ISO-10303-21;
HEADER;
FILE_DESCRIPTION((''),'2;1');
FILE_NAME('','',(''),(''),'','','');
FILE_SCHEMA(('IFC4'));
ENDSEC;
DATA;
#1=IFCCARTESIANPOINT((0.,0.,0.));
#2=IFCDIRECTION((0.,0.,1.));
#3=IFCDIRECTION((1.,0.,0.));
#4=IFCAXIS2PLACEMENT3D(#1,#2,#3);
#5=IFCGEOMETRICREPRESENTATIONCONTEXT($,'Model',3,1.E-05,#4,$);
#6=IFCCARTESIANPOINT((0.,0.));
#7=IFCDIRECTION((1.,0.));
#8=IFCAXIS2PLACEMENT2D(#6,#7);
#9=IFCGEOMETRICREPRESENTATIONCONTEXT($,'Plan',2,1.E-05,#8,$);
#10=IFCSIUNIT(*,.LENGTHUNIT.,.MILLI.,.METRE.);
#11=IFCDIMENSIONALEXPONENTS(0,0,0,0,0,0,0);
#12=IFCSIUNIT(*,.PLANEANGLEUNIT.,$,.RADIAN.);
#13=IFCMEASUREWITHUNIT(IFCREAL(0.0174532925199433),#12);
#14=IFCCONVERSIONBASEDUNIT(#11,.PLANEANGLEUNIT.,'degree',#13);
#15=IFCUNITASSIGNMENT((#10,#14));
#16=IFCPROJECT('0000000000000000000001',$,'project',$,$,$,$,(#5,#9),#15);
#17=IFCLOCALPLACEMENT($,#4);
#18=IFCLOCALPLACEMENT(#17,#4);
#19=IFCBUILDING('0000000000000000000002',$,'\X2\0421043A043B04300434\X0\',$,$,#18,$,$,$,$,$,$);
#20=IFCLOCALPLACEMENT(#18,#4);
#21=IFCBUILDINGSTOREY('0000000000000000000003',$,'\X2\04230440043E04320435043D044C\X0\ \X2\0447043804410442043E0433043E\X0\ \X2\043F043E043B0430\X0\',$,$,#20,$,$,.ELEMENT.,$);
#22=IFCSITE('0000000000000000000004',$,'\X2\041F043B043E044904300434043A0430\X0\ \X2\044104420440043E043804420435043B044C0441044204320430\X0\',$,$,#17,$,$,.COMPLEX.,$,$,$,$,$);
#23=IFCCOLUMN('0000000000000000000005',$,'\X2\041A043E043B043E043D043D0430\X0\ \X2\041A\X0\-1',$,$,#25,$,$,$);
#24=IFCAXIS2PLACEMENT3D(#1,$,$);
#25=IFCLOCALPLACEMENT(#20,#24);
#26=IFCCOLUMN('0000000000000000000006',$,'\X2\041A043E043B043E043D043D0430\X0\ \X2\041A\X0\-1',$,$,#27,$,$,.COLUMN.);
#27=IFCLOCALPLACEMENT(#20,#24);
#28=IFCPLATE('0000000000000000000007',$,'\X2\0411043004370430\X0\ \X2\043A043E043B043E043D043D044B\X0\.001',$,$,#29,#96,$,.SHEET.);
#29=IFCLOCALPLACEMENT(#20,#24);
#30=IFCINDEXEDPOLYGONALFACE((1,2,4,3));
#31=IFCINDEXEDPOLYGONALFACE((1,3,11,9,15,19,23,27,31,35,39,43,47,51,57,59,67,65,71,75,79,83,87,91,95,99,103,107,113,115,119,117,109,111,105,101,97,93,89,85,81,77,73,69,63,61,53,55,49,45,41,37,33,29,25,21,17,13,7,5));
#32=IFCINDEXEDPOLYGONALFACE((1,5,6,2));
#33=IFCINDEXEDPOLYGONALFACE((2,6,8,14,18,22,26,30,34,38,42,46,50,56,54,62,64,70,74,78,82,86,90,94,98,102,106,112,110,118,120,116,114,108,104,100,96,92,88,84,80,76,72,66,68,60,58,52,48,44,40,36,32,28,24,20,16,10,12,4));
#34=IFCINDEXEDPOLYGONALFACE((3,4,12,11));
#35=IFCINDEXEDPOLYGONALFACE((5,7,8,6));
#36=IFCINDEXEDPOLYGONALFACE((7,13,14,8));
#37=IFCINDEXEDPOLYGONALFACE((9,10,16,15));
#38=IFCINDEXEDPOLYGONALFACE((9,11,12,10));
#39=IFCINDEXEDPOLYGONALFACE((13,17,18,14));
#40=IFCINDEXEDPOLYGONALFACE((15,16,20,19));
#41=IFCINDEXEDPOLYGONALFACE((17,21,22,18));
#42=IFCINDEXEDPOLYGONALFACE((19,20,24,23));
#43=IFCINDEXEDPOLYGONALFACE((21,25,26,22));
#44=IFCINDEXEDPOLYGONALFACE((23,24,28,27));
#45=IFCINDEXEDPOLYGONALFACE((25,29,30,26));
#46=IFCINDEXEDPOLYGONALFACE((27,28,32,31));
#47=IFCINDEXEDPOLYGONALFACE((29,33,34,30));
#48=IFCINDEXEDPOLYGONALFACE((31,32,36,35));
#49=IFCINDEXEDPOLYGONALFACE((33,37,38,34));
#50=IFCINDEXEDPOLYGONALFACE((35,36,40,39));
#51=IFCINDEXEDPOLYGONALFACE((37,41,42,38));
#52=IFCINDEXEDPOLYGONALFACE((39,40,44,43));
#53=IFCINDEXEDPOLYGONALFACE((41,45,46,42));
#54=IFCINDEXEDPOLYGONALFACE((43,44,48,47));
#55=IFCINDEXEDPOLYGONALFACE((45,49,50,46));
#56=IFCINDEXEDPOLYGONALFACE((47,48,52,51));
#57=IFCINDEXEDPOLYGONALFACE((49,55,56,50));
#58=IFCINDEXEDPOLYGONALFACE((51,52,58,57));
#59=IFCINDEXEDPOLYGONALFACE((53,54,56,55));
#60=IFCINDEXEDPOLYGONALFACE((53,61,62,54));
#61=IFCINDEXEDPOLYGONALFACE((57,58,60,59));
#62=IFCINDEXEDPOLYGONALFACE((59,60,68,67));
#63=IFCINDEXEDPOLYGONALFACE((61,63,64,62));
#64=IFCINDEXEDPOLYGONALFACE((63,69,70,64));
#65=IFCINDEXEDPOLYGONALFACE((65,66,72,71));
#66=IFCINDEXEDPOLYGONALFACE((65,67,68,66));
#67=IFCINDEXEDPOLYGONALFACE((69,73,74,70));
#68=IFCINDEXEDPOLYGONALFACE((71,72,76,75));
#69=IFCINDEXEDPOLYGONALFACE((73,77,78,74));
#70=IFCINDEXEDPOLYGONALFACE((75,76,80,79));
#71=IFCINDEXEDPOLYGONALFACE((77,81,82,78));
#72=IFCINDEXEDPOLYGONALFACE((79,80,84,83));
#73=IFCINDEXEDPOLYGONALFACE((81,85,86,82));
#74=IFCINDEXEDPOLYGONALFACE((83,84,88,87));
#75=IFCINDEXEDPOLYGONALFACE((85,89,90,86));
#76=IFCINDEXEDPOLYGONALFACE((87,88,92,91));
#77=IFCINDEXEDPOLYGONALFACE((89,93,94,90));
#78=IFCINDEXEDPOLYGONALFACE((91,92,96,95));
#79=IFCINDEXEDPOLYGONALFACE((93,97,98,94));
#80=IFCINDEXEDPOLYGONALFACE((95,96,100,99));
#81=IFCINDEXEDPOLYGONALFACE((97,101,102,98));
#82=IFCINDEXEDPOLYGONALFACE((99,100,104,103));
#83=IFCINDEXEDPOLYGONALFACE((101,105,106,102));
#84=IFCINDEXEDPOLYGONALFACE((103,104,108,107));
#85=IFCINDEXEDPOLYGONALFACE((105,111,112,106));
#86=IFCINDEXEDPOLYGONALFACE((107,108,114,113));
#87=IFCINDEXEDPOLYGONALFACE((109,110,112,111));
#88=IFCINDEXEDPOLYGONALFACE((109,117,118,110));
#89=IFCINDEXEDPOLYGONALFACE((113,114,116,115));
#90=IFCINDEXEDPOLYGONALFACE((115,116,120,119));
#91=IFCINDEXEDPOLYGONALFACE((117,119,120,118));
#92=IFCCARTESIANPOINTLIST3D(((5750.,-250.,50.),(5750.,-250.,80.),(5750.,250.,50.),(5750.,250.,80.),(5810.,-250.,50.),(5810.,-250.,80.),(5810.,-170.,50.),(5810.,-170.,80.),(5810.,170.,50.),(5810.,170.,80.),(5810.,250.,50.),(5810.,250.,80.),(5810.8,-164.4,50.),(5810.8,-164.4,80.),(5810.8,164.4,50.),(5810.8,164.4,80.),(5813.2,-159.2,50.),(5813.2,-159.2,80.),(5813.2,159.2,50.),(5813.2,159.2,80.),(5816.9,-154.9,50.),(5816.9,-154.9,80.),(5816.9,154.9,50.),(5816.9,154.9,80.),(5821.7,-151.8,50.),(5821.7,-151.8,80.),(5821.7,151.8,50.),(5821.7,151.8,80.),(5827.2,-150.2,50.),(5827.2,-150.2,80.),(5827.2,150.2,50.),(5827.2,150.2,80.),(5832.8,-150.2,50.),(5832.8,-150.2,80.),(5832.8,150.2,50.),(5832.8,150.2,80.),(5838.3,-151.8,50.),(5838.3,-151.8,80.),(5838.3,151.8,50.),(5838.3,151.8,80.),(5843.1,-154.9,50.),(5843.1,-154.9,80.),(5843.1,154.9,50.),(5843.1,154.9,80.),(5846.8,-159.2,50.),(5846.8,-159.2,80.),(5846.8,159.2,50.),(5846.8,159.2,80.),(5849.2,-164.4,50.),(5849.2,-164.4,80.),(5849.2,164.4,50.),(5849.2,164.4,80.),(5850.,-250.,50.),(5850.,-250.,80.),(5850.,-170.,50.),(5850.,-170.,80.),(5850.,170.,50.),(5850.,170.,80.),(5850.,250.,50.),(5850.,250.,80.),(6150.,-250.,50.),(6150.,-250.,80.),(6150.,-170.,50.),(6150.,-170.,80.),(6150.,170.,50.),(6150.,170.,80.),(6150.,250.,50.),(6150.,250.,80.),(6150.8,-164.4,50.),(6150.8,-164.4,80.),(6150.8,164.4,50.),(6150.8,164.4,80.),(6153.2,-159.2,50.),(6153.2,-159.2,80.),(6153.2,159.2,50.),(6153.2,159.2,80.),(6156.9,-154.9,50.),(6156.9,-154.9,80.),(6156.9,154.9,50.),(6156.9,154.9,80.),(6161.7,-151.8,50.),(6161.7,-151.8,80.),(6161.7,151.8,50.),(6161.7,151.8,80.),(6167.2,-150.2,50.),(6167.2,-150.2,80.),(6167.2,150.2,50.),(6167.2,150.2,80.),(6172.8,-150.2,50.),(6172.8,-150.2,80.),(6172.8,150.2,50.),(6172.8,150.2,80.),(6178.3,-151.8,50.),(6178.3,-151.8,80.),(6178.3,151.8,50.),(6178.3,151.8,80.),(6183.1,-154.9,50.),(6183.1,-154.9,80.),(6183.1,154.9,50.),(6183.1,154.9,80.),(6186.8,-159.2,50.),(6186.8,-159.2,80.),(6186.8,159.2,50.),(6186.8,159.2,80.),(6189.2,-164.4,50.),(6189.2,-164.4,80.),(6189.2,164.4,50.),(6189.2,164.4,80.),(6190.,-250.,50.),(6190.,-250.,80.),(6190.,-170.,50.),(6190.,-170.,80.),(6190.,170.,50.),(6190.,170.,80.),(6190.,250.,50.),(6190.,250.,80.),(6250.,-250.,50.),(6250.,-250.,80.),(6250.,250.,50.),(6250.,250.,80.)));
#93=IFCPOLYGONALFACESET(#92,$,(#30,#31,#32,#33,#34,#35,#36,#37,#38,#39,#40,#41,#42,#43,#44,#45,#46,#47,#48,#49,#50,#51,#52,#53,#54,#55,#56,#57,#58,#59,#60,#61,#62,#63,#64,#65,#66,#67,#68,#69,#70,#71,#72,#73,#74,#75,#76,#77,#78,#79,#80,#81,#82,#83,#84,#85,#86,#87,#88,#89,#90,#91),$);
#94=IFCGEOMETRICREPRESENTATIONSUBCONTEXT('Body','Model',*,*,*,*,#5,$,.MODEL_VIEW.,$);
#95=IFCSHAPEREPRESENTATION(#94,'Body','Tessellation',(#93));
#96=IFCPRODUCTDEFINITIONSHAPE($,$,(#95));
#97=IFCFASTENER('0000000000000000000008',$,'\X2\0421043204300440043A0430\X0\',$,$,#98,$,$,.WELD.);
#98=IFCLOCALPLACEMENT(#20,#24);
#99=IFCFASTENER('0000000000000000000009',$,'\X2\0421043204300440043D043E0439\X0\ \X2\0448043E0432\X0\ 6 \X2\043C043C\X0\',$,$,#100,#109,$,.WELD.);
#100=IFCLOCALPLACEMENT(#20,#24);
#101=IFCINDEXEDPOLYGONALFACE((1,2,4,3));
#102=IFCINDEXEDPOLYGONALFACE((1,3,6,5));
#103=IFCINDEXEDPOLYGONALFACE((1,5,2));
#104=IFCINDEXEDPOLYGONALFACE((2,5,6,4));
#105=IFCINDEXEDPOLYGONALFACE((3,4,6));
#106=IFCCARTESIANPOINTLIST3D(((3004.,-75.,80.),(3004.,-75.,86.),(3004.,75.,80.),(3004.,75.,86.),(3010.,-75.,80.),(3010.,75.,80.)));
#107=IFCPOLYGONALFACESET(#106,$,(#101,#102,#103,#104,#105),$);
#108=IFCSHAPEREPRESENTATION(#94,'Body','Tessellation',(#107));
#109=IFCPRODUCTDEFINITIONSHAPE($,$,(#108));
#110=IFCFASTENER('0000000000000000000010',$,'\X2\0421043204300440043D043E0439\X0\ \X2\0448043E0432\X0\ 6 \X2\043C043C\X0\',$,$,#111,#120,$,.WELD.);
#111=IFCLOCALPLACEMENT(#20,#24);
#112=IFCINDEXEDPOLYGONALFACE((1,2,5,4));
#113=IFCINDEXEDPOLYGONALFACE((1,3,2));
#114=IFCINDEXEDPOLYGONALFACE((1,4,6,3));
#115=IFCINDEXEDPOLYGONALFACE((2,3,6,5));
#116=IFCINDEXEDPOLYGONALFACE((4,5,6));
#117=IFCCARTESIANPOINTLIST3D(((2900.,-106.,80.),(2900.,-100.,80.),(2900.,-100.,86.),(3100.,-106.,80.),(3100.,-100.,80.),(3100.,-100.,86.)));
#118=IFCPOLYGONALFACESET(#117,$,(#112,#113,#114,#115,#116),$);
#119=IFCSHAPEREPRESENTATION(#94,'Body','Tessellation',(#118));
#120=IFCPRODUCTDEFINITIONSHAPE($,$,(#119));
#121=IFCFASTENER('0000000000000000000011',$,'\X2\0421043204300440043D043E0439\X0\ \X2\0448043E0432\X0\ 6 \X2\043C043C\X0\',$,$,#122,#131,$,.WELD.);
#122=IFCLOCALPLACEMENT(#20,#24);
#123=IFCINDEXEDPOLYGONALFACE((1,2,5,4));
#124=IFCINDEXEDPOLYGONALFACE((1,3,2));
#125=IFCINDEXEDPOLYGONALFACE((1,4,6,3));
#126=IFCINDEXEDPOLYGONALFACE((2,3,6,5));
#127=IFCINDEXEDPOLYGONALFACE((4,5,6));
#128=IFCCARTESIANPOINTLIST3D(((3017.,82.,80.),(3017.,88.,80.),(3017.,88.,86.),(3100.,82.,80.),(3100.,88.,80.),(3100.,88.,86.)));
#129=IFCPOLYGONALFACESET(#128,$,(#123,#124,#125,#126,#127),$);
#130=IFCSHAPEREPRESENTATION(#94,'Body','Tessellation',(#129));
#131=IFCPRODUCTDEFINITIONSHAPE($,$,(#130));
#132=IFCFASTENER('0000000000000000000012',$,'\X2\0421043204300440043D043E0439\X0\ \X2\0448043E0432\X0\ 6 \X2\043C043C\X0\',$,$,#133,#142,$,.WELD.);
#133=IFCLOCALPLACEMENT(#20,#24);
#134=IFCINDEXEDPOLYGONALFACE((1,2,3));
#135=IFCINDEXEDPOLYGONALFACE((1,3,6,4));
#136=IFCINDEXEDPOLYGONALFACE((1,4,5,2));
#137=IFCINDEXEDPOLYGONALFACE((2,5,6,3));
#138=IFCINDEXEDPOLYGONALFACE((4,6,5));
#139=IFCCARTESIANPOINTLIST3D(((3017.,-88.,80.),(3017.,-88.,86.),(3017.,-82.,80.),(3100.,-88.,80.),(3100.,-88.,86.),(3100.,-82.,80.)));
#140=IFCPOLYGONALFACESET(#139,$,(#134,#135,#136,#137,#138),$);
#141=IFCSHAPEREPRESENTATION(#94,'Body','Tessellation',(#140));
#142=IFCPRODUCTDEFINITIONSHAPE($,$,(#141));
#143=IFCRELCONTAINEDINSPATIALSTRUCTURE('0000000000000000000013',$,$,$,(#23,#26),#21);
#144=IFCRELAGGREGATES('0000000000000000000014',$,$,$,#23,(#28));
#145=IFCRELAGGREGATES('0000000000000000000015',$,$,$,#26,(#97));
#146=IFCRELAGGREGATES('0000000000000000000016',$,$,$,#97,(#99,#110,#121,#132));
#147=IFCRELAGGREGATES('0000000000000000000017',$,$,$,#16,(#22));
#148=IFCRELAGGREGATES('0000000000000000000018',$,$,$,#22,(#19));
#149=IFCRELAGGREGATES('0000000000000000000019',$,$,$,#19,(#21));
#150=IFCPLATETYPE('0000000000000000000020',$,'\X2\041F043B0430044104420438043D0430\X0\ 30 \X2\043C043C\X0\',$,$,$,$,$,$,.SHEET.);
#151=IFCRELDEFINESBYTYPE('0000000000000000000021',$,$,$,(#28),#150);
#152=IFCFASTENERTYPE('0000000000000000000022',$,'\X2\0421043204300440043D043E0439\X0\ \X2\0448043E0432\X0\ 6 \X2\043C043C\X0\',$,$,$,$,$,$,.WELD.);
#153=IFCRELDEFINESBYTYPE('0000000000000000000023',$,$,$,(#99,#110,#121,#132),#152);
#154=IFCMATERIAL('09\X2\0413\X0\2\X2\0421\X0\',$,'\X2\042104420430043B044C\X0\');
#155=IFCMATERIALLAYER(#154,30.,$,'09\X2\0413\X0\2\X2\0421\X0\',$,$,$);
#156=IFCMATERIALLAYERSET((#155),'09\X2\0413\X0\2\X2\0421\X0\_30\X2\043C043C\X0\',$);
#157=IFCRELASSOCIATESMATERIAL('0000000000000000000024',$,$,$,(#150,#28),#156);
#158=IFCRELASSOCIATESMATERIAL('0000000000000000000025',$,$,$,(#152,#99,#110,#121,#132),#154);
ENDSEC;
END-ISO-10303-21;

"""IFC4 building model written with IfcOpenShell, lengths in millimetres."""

from ifc_helpers import new_model, entity, si_unit, converted_unit, frame, origin_with_axes, origin_2d_with_axis, place, context, subcontext, project, spatial, line, arc, indexed_curve, outline, extrude, material, layer, layer_set, layer_usage, material_profile, profile_set, profile_usage, type_object, element, aggregate, save


model = new_model("IFC4")

# Units and contexts
model_context = context("Model", 3, precision=1e-05, world=origin_with_axes())
plan_context = context("Plan", 2, precision=1e-05, world=origin_2d_with_axis())
body_context = subcontext(model_context, "Body", "Model", "MODEL_VIEW")
ifc_project = project(units=[si_unit("LENGTHUNIT", "METRE", prefix="MILLI"), converted_unit("PLANEANGLEUNIT", "degree", entity("IfcReal", 0.0174532925199433), si_unit("PLANEANGLEUNIT", "RADIAN"), dimensions=[0, 0, 0, 0, 0, 0, 0])], contexts=[model_context, plan_context])

# Site, building, storey
site_placement = place(None, origin_with_axes())
site = spatial("IfcSite", under=ifc_project, at=site_placement, Name="Площадка строительства", CompositionType="COMPLEX")
building_placement = place(site_placement, origin_with_axes())
building = spatial("IfcBuilding", under=site, at=building_placement, Name="Склад")
storey_placement = place(building_placement, origin_with_axes())
storey = spatial("IfcBuildingStorey", under=building, at=storey_placement, Name="Уровень чистого пола", CompositionType="ELEMENT")

# Column
column_1_placement = place(storey_placement, origin_with_axes())
column_1 = element("IfcColumn", 1, at=column_1_placement, inside=storey, Name="Колонна К-1")

# Shared definitions
ifc_material_1 = material(Name="09Г2С", Category="Сталь")

# Column
column_2_placement = place(storey_placement, origin_with_axes())
column_2 = element("IfcColumn", 2, at=column_2_placement, inside=storey, Name="Колонна К-1", PredefinedType="COLUMN")
ifc_layer = layer(ifc_material_1, 30.0, Name="09Г2С")
ifc_layer_set = layer_set([ifc_layer], Name="09Г2С_30мм")
plate_type = type_object("IfcPlateType", Name="Пластина 30 мм", PredefinedType="SHEET", material=ifc_layer_set)

# Plate
ifc_layer_usage_1 = layer_usage(ifc_layer_set, "AXIS3", "POSITIVE", 0.0)
plate_1_placement = place(column_1_placement, frame((6000.0, 0.0, 50.0), z_axis=(0.0, 0.0, 1.0), x_axis=(1.0, 0.0, 0.0)))
plate_1 = element("IfcPlate", 3, at=plate_1_placement, type_object=plate_type, material=ifc_layer_usage_1, Name="База колонны.001", PredefinedType="SHEET", context=body_context, shape_type="SweptSolid", body=[
    extrude(outline(indexed_curve([(190.0, 250.0), (250.0, 250.0), (250.0, -250.0), (190.0, -250.0), (190.0, -170.0), (170.0, -150.0), (150.0, -170.0), (150.0, -250.0), (-150.0, -250.0), (-150.0, -170.0), (-170.0, -150.0), (-190.0, -170.0), (-190.0, -250.0), (-250.0, -250.0), (-250.0, 250.0), (-190.0, 250.0), (-190.0, 170.0), (-170.0, 150.0), (-150.0, 170.0), (-150.0, 250.0), (150.0, 250.0), (150.0, 170.0), (170.0, 150.0), (190.0, 170.0)], segments=[line(21, 20), line(20, 19), arc(19, 18, 17), line(17, 16), line(16, 15), line(15, 14), line(14, 13), line(13, 12), arc(12, 11, 10), line(10, 9), line(9, 8), line(8, 7), arc(7, 6, 5), line(5, 4), line(4, 3), line(3, 2), line(2, 1), line(1, 24), arc(24, 23, 22), line(22, 21)], self_intersect=False)), None, (0.0, 0.0, 1.0), 30.0),
])
aggregate(column_1, [plate_1])

# Fasteners
fastener_1_placement = place(column_2_placement, frame((3000.0, 0.0, 0.0), z_axis=(0.0, 0.0, 1.0), x_axis=(1.0, 0.0, 0.0)))
fastener_1 = element("IfcFastener", 4, at=fastener_1_placement, Name="Сварка", PredefinedType="WELD")
aggregate(column_2, [fastener_1])
ifc_material_profile_1 = material_profile(ifc_material_1, outline(indexed_curve([(0.0, 0.0), (6.0, 0.0), (0.0, 6.0)], segments=[line(2, 3), line(3, 1), line(1, 2)], self_intersect=False)))
ifc_profile_set_1 = profile_set([ifc_material_profile_1])
ifc_profile_usage_1 = profile_usage(ifc_profile_set_1, cardinal=5)
fastener_type = type_object("IfcFastenerType", Name="Сварной шов 6 мм", PredefinedType="WELD", material=ifc_profile_set_1)
fastener_2_placement = place(fastener_1_placement, frame((4.0, 75.0, 80.0), z_axis=(0.0, -1.0, 0.0), x_axis=(1.0, 0.0, 0.0)))
fastener_2 = element("IfcFastener", 5, at=fastener_2_placement, type_object=fastener_type, material=ifc_profile_usage_1, Name="Сварной шов 6 мм", PredefinedType="WELD", context=body_context, shape_type="SweptSolid", body=[
    extrude(outline(indexed_curve([(0.0, 0.0), (6.0, 0.0), (0.0, 6.0)], segments=[line(2, 3), line(3, 1), line(1, 2)], self_intersect=False)), origin_with_axes(), (0.0, 0.0, 1.0), 150.0),
])
ifc_profile_usage_2 = profile_usage(ifc_profile_set_1, cardinal=5)
fastener_3_placement = place(fastener_1_placement, frame((100.0, -100.0, 80.0), z_axis=(-1.0, 0.0, 0.0), x_axis=(0.0, -1.0, 0.0)))
fastener_3 = element("IfcFastener", 6, at=fastener_3_placement, type_object=fastener_type, material=ifc_profile_usage_2, Name="Сварной шов 6 мм", PredefinedType="WELD", context=body_context, shape_type="SweptSolid", body=[
    extrude(outline(indexed_curve([(0.0, 0.0), (6.0, 0.0), (0.0, 6.0)], segments=[line(2, 3), line(3, 1), line(1, 2)], self_intersect=False)), origin_with_axes(), (0.0, 0.0, 1.0), 200.0),
])
ifc_profile_usage_3 = profile_usage(ifc_profile_set_1, cardinal=5)
fastener_4_placement = place(fastener_1_placement, frame((100.0, 88.0, 80.0), z_axis=(-1.0, 0.0, 0.0), x_axis=(0.0, -1.0, 0.0)))
fastener_4 = element("IfcFastener", 7, at=fastener_4_placement, type_object=fastener_type, material=ifc_profile_usage_3, Name="Сварной шов 6 мм", PredefinedType="WELD", context=body_context, shape_type="SweptSolid", body=[
    extrude(outline(indexed_curve([(0.0, 0.0), (6.0, 0.0), (0.0, 6.0)], segments=[line(2, 3), line(3, 1), line(1, 2)], self_intersect=False)), origin_with_axes(), (0.0, 0.0, 1.0), 83.0),
])
ifc_profile_usage_4 = profile_usage(ifc_profile_set_1, cardinal=5)
fastener_5_placement = place(fastener_1_placement, frame((17.0, -88.0, 80.0), z_axis=(1.0, 0.0, 0.0), x_axis=(0.0, 1.0, 0.0)))
fastener_5 = element("IfcFastener", 8, at=fastener_5_placement, type_object=fastener_type, material=ifc_profile_usage_4, Name="Сварной шов 6 мм", PredefinedType="WELD", context=body_context, shape_type="SweptSolid", body=[
    extrude(outline(indexed_curve([(0.0, 0.0), (6.0, 0.0), (0.0, 6.0)], segments=[line(2, 3), line(3, 1), line(1, 2)], self_intersect=False)), origin_with_axes(), (0.0, 0.0, 1.0), 83.0),
])
aggregate(fastener_1, [fastener_2, fastener_3, fastener_4, fastener_5])

save(model, "model.ifc")
